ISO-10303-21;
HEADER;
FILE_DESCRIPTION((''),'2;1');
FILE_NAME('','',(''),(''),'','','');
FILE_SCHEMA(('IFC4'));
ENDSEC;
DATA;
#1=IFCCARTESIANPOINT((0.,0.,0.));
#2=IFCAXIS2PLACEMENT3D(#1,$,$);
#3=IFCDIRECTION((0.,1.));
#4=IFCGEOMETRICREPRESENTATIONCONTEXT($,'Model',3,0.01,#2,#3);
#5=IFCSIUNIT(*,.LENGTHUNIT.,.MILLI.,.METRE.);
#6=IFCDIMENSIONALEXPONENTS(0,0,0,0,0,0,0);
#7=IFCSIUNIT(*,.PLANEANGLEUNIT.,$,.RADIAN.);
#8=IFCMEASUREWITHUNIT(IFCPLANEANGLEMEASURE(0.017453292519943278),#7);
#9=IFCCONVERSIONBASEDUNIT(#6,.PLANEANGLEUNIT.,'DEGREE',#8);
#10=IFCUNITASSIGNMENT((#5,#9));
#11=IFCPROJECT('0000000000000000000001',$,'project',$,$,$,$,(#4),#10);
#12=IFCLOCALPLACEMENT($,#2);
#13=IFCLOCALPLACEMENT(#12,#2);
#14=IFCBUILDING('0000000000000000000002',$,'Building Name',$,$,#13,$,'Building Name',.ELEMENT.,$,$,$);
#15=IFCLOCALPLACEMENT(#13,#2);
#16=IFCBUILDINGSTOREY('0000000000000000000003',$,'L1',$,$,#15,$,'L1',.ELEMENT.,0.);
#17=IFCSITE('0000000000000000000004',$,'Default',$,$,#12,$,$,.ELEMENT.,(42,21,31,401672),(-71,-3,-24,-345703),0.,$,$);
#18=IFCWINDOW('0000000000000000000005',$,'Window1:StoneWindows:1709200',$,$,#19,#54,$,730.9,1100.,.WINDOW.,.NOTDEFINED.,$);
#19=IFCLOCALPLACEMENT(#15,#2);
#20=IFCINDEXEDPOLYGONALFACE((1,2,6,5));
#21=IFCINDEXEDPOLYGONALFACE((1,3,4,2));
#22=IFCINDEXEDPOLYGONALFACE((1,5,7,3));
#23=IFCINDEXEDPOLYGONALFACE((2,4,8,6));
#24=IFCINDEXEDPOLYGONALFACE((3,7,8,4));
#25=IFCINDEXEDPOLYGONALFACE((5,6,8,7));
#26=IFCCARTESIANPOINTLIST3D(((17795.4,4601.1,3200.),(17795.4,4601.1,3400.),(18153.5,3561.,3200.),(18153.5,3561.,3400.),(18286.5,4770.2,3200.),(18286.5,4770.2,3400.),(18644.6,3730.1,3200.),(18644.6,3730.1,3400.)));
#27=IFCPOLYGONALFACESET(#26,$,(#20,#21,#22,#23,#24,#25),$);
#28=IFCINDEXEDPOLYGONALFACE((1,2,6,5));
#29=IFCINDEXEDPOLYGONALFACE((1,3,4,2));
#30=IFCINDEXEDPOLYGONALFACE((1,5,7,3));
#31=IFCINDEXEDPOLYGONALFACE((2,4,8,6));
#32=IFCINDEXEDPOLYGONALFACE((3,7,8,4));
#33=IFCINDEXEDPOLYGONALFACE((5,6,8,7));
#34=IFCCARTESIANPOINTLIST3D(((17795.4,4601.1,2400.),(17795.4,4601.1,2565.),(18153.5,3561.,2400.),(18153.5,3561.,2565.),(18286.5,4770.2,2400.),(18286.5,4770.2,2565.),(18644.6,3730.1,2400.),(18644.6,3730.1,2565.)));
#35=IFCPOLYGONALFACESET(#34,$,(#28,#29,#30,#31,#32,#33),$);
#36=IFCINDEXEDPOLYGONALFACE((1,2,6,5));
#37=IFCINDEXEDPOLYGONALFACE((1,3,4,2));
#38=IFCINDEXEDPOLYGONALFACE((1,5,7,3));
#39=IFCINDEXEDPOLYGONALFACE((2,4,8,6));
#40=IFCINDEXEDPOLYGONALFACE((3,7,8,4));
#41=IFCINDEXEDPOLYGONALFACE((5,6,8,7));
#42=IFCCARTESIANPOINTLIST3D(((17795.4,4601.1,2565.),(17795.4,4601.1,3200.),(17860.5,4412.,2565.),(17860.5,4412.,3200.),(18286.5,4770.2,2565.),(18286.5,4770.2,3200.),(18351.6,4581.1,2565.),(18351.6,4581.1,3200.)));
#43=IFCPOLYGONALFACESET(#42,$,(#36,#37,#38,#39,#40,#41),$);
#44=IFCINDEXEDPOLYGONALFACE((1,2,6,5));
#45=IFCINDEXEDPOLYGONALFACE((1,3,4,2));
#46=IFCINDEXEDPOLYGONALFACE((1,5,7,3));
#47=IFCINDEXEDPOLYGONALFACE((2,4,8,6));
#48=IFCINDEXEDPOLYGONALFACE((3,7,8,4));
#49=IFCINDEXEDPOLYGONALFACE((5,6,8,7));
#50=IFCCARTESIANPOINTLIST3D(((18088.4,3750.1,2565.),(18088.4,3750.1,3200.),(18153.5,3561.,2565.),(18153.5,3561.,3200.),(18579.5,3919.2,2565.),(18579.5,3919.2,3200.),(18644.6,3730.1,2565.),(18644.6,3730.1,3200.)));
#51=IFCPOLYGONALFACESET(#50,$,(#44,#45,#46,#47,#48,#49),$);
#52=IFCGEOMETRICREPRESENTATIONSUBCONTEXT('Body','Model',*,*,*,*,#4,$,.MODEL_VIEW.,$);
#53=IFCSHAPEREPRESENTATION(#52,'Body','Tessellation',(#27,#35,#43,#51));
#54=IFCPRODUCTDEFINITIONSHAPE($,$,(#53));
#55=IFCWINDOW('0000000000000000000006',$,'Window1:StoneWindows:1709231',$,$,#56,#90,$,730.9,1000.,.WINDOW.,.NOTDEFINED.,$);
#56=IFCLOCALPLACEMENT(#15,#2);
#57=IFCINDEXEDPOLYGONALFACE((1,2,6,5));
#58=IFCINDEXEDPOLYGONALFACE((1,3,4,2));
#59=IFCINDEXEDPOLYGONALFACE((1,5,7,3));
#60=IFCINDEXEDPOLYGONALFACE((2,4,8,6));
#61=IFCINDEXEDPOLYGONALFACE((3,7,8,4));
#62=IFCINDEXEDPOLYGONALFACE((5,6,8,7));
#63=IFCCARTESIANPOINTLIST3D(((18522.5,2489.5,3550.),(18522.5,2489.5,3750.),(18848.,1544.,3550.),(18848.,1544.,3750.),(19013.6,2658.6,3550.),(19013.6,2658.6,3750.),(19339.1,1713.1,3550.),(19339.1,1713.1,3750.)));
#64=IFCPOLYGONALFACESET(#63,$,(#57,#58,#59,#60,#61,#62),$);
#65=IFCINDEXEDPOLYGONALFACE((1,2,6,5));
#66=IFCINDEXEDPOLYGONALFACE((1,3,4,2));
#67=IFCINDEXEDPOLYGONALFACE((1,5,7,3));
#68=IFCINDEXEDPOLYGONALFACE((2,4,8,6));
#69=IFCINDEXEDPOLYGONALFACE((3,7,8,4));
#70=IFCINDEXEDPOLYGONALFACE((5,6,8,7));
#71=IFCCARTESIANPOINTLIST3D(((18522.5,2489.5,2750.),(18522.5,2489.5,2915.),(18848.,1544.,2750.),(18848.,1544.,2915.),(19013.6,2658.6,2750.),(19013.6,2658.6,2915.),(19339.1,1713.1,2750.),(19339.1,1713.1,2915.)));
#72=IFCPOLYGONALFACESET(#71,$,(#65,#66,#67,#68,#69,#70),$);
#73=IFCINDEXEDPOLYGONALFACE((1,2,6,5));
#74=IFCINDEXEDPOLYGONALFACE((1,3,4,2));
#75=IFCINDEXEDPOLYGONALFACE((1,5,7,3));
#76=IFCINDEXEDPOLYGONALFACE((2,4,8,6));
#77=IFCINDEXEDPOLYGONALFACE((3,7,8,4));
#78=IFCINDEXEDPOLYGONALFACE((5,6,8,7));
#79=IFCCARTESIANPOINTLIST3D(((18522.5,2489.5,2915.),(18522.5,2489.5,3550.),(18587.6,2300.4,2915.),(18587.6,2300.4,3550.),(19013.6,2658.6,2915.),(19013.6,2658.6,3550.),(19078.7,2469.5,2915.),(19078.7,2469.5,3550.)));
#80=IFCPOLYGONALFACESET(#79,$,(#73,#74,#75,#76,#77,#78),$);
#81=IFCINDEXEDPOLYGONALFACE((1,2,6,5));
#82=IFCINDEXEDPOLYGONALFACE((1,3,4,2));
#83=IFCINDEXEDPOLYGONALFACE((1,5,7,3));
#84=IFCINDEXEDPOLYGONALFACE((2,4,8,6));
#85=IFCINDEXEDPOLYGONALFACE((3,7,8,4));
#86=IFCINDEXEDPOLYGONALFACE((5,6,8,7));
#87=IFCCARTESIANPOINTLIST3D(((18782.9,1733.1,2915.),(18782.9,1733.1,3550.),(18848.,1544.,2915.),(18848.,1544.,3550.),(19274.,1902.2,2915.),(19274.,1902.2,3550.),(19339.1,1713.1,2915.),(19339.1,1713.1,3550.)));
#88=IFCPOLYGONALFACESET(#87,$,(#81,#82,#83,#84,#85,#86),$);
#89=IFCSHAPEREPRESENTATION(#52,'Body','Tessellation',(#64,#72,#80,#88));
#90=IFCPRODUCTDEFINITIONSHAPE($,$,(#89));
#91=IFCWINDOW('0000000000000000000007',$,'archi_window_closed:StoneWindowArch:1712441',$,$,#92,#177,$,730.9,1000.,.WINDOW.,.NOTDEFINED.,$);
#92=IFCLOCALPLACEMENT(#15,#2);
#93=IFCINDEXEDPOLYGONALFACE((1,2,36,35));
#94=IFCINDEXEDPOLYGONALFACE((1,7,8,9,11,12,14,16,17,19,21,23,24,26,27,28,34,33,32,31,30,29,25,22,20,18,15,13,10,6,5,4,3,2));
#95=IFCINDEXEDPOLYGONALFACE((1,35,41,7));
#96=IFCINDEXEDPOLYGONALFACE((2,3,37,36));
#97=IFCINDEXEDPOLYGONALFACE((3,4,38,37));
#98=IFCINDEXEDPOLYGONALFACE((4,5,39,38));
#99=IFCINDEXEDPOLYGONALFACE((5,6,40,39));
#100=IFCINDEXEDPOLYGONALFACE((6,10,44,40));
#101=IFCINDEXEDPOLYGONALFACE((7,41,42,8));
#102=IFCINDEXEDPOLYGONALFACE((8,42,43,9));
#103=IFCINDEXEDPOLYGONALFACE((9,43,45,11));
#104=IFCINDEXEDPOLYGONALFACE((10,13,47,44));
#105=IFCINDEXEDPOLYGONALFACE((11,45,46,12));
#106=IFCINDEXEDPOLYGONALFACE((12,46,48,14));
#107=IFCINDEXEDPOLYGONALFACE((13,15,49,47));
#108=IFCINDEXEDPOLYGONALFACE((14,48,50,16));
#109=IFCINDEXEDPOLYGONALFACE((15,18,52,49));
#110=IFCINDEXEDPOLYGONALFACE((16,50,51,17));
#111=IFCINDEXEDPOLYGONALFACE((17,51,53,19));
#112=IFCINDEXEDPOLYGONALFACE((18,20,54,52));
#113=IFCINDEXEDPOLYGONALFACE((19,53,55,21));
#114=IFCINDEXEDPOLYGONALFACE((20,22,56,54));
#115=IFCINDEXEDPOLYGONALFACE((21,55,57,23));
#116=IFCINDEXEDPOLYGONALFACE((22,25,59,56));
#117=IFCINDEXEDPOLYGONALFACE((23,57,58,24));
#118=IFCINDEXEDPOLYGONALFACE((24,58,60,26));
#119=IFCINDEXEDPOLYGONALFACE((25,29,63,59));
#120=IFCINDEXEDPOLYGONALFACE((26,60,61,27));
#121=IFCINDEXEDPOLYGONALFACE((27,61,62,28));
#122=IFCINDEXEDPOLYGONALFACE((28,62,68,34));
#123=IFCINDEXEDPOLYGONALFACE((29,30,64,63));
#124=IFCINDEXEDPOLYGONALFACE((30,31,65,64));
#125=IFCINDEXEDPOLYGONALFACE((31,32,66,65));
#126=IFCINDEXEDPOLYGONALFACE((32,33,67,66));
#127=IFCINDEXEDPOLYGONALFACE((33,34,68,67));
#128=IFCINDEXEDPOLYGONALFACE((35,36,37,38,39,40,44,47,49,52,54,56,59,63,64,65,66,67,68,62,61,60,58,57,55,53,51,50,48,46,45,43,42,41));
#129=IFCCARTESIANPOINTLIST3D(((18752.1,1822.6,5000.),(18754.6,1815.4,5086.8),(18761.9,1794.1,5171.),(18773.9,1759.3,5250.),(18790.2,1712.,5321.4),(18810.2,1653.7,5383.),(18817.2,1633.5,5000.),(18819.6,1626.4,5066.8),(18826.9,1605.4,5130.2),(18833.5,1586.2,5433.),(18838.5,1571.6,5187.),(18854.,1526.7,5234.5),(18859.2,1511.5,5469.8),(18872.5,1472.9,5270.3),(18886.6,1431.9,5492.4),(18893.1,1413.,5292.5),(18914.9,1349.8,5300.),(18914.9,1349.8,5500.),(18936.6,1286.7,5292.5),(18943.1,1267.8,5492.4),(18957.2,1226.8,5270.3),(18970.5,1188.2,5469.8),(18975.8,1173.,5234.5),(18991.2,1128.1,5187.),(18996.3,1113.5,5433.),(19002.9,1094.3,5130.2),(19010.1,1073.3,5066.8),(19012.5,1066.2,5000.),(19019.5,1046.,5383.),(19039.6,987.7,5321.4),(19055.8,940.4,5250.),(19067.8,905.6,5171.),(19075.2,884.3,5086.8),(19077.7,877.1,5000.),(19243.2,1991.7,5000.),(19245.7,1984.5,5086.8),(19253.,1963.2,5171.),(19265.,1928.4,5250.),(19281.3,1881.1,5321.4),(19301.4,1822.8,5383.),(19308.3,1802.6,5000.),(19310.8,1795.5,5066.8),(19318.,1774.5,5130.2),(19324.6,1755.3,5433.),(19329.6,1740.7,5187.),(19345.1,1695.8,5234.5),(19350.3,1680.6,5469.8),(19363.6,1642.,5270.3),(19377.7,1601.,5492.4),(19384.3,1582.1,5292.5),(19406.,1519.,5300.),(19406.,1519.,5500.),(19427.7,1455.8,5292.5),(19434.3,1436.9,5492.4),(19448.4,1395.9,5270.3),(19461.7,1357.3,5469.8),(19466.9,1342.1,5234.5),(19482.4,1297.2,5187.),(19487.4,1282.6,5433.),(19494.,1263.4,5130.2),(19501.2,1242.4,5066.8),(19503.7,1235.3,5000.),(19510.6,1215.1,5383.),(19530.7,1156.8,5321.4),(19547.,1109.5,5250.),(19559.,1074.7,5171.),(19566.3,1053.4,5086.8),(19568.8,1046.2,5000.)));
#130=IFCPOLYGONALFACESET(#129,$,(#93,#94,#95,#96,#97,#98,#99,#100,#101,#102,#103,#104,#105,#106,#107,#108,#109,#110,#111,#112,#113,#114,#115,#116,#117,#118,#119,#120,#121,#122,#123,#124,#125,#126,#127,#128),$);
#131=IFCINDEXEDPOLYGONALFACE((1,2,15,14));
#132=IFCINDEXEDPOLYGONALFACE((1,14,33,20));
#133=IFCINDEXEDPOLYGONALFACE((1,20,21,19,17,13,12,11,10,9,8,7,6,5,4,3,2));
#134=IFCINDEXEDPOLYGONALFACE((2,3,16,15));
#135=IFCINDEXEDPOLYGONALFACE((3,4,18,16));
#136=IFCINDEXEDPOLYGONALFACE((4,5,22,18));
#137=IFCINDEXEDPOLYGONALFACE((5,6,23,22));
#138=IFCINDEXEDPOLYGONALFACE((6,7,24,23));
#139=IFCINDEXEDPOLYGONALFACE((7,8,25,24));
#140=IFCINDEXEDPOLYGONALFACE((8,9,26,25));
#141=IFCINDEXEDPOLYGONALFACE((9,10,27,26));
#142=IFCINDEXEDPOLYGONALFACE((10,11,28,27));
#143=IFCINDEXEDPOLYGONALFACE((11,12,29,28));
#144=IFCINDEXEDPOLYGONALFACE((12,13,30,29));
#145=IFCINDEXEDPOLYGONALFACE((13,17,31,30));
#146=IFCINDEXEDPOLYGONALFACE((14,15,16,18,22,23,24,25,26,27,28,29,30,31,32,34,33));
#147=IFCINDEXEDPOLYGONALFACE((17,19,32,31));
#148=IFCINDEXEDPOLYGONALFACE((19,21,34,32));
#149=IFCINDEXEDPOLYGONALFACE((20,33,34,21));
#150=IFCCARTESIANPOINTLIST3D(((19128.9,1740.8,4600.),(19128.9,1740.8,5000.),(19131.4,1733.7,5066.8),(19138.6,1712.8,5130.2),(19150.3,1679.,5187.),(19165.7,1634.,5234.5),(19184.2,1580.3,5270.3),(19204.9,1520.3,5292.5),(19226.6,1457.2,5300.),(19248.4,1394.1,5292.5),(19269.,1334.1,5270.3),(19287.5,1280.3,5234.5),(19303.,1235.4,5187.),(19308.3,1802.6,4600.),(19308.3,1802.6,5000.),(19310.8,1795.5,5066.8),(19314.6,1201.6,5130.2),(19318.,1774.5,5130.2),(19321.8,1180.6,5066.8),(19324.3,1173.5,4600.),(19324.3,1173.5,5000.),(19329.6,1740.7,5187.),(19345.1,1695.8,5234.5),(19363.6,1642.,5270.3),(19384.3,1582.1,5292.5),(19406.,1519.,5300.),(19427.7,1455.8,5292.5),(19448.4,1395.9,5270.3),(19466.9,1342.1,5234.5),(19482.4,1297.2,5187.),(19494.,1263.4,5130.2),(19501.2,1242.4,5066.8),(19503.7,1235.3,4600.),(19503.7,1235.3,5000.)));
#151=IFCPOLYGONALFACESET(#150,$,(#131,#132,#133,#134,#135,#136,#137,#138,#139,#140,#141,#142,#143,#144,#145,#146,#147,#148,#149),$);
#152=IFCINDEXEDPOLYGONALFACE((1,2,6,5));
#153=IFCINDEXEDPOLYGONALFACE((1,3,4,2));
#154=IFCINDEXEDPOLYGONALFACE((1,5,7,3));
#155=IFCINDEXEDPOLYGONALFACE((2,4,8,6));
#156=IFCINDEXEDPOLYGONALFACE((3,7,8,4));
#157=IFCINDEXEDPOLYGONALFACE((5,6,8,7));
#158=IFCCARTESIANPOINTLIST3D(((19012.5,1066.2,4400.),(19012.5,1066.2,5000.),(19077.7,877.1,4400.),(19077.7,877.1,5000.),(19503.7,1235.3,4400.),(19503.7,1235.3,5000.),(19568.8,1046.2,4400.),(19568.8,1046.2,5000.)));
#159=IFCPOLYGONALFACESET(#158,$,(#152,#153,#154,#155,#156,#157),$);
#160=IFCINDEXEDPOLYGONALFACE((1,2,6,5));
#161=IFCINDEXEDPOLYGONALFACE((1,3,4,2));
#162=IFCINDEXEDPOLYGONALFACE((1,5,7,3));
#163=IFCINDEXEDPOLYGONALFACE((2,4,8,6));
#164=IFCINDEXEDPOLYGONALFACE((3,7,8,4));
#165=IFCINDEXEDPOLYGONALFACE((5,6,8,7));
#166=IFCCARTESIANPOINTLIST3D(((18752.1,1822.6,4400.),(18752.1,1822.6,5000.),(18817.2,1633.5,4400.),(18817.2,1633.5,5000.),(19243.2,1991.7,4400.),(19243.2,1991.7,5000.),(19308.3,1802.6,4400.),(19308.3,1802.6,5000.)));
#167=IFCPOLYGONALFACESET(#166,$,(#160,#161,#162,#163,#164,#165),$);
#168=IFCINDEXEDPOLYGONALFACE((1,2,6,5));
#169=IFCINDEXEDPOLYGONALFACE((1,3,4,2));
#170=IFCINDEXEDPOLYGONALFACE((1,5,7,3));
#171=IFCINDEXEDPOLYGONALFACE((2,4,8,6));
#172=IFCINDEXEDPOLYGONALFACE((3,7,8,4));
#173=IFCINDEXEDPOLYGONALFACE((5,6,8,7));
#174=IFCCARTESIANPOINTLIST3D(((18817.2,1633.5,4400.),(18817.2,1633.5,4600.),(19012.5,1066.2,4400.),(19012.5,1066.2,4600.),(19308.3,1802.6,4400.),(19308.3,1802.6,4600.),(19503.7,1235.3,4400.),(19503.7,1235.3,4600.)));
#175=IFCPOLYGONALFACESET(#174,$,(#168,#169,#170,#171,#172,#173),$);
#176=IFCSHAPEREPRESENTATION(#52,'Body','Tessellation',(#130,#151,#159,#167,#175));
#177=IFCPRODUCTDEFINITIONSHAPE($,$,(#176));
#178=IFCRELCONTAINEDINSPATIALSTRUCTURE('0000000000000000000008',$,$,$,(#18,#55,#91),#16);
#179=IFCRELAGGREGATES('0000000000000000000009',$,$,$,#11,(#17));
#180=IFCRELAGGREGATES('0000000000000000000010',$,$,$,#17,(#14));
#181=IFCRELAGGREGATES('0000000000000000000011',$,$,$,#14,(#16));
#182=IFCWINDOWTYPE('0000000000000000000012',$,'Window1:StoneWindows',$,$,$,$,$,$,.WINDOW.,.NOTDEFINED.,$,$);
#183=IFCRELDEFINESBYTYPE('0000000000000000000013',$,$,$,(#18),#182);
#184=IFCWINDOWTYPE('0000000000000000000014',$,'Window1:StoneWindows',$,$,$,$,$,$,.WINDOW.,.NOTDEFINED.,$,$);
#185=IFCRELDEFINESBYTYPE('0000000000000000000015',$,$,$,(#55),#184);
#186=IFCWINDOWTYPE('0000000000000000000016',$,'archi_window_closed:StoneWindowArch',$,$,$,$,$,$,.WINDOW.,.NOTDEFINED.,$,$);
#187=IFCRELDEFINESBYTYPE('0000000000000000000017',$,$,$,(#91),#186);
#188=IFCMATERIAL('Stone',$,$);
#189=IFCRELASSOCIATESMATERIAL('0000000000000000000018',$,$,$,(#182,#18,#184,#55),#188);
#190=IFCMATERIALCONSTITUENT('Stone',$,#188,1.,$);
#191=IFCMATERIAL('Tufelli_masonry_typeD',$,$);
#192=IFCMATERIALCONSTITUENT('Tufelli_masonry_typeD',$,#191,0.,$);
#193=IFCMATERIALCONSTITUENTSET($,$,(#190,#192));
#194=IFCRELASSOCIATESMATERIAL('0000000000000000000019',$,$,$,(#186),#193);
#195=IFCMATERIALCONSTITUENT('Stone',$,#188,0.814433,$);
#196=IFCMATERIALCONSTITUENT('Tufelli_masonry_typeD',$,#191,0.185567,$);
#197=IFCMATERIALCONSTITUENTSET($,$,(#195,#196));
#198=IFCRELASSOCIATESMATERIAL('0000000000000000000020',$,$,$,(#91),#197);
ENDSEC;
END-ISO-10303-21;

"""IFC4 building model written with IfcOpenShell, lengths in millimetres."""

from ifc_helpers import new_model, entity, si_unit, converted_unit, direction, frame, origin, place, context, subcontext, project, spatial, line, arc, indexed_curve, outline, extrude, source, transform, mapped, material, constituent, constituent_set, type_object, type_shapes, element, save


model = new_model("IFC4")

# Units and contexts
model_context = context("Model", 3, precision=0.01, world=origin(), true_north=direction((0.0, 1.0)))
body_context = subcontext(model_context, "Body", "Model", "MODEL_VIEW")
ifc_project = project(units=[si_unit("LENGTHUNIT", "METRE", prefix="MILLI"), converted_unit("PLANEANGLEUNIT", "DEGREE", entity("IfcPlaneAngleMeasure", 0.017453292519943278), si_unit("PLANEANGLEUNIT", "RADIAN"), dimensions=[0, 0, 0, 0, 0, 0, 0])], contexts=[model_context])

# Site, building, storey
site_placement = place(None, origin())
site = spatial("IfcSite", under=ifc_project, at=site_placement, Name="Default", CompositionType="ELEMENT", RefLatitude=(42, 21, 31, 401672), RefLongitude=(-71, -3, -24, -345703), RefElevation=0.0)
building_placement = place(site_placement, origin())
building = spatial("IfcBuilding", under=site, at=building_placement, Name="Building Name", LongName="Building Name", CompositionType="ELEMENT")
storey_placement = place(building_placement, origin())
storey = spatial("IfcBuildingStorey", under=building, at=storey_placement, Name="L1", LongName="L1", CompositionType="ELEMENT", Elevation=0.0)

# Shared definitions
ifc_material_1 = material(Name="Stone")
ifc_material_2 = material(Name="Tufelli_masonry_typeD")

# Windows
window_type_1 = type_object("IfcWindowType", Name="Window1:StoneWindows", PartitioningType="NOTDEFINED", PredefinedType="WINDOW", material=ifc_material_1)
shared_shape_1 = source(origin(), body_context, "Body", "SweptSolid", [
    extrude(outline(indexed_curve([(-259.7, -550.0), (259.7, -550.0), (259.7, 550.0), (-259.7, 550.0), (-259.7, -550.0)], self_intersect=False)), frame((0.0, 0.0, 1600.0), z_axis=(0.0, 0.0, 1.0), x_axis=(0.0, 1.0, 0.0)), (0.0, 0.0, 1.0), 200.0),
    extrude(outline(indexed_curve([(-259.7, -550.0), (259.7, -550.0), (259.7, 550.0), (-259.7, 550.0), (-259.7, -550.0)], self_intersect=False)), frame((0.0, 0.0, 800.0), z_axis=(0.0, 0.0, 1.0), x_axis=(0.0, 1.0, 0.0)), (0.0, 0.0, 1.0), 165.0),
    extrude(outline(indexed_curve([(-259.7, -100.0), (259.7, -100.0), (259.7, 100.0), (-259.7, 100.0), (-259.7, -100.0)], self_intersect=False)), frame((-450.0, 0.0, 965.0), z_axis=(0.0, 0.0, 1.0), x_axis=(0.0, 1.0, 0.0)), (0.0, 0.0, 1.0), 635.0),
    extrude(outline(indexed_curve([(-259.7, -100.0), (259.7, -100.0), (259.7, 100.0), (-259.7, 100.0), (-259.7, -100.0)], self_intersect=False)), frame((450.0, 0.0, 965.0), z_axis=(0.0, 0.0, 1.0), x_axis=(0.0, 1.0, 0.0)), (0.0, 0.0, 1.0), 635.0),
])
type_shapes(window_type_1, [shared_shape_1])
window_1_placement = place(storey_placement, frame((18220.0, 4165.6, 1600.0), z_axis=(0.0, 0.0, 1.0), x_axis=(0.325568, -0.945519, 0.0)))
element("IfcWindow", 1, at=window_1_placement, inside=storey, type_object=window_type_1, material=ifc_material_1, Name="Window1:StoneWindows:1709200", OverallHeight=730.9, OverallWidth=1100.0, PartitioningType="NOTDEFINED", PredefinedType="WINDOW", context=body_context, shape_type="MappedRepresentation", body=[
    mapped(shared_shape_1, transform((0.0, 0.0, 0.0), scale=1.0)),
])
window_type_2 = type_object("IfcWindowType", Name="Window1:StoneWindows", PartitioningType="NOTDEFINED", PredefinedType="WINDOW", material=ifc_material_1)
shared_shape_2 = source(origin(), body_context, "Body", "SweptSolid", [
    extrude(outline(indexed_curve([(-259.7, -500.0), (259.7, -500.0), (259.7, 500.0), (-259.7, 500.0), (-259.7, -500.0)], self_intersect=False)), frame((0.0, 0.0, 1600.0), z_axis=(0.0, 0.0, 1.0), x_axis=(0.0, 1.0, 0.0)), (0.0, 0.0, 1.0), 200.0),
    extrude(outline(indexed_curve([(-259.7, -500.0), (259.7, -500.0), (259.7, 500.0), (-259.7, 500.0), (-259.7, -500.0)], self_intersect=False)), frame((0.0, 0.0, 800.0), z_axis=(0.0, 0.0, 1.0), x_axis=(0.0, 1.0, 0.0)), (0.0, 0.0, 1.0), 165.0),
    extrude(outline(indexed_curve([(-259.7, -100.0), (259.7, -100.0), (259.7, 100.0), (-259.7, 100.0), (-259.7, -100.0)], self_intersect=False)), frame((-400.0, 0.0, 965.0), z_axis=(0.0, 0.0, 1.0), x_axis=(0.0, 1.0, 0.0)), (0.0, 0.0, 1.0), 635.0),
    extrude(outline(indexed_curve([(-259.7, -100.0), (259.7, -100.0), (259.7, 100.0), (-259.7, 100.0), (-259.7, -100.0)], self_intersect=False)), frame((400.0, 0.0, 965.0), z_axis=(0.0, 0.0, 1.0), x_axis=(0.0, 1.0, 0.0)), (0.0, 0.0, 1.0), 635.0),
])
type_shapes(window_type_2, [shared_shape_2])
window_2_placement = place(storey_placement, frame((18930.8, 2101.3, 1950.0), z_axis=(0.0, 0.0, 1.0), x_axis=(0.325568, -0.945519, 0.0)))
element("IfcWindow", 2, at=window_2_placement, inside=storey, type_object=window_type_2, material=ifc_material_1, Name="Window1:StoneWindows:1709231", OverallHeight=730.9, OverallWidth=1000.0, PartitioningType="NOTDEFINED", PredefinedType="WINDOW", context=body_context, shape_type="MappedRepresentation", body=[
    mapped(shared_shape_2, transform((0.0, 0.0, 0.0), scale=1.0)),
])
ifc_constituent_1 = constituent(ifc_material_1, Name="Stone", fraction=0.814433)
ifc_constituent_2 = constituent(ifc_material_2, Name="Tufelli_masonry_typeD", fraction=0.185567)
ifc_constituent_set_1 = constituent_set(constituents=[ifc_constituent_1, ifc_constituent_2])
ifc_constituent_3 = constituent(ifc_material_1, Name="Stone", fraction=1.0)
ifc_constituent_4 = constituent(ifc_material_2, Name="Tufelli_masonry_typeD", fraction=0.0)
ifc_constituent_set_2 = constituent_set(constituents=[ifc_constituent_3, ifc_constituent_4])
window_type_3 = type_object("IfcWindowType", Name="archi_window_closed:StoneWindowArch", PartitioningType="NOTDEFINED", PredefinedType="WINDOW", material=ifc_constituent_set_2)
shared_shape_3 = source(origin(), body_context, "Body", "SweptSolid", [
    extrude(outline(indexed_curve([(300.0, 0.0), (500.0, 0.0), (0.0, 500.0), (-500.0, 0.0), (-300.0, 0.0), (0.0, 300.0)], segments=[line(1, 2), arc(2, 3, 4), line(4, 5), arc(5, 6, 1)], self_intersect=False)), frame((0.0, -259.7, 1400.0), z_axis=(0.0, -1.0, 0.0), x_axis=(1.0, 0.0, 0.0)), (0.0, 0.0, -1.0), 519.4),
    extrude(outline(indexed_curve([(-200.0, -300.0), (200.0, -300.0), (200.0, 300.0), (-200.0, 300.0), (-500.0, 0.0)], segments=[line(1, 2, 3, 4), arc(4, 5, 1)], self_intersect=False)), frame((0.0, 70.0, 1200.0), z_axis=(0.0, 1.0, 0.0), x_axis=(0.0, 0.0, -1.0)), (0.0, 0.0, 1.0), 189.7),
    extrude(outline(indexed_curve([(-259.7, -100.0), (259.7, -100.0), (259.7, 100.0), (-259.7, 100.0), (-259.7, -100.0)], self_intersect=False)), frame((400.0, 0.0, 800.0), z_axis=(0.0, 0.0, 1.0), x_axis=(0.0, 1.0, 0.0)), (0.0, 0.0, 1.0), 600.0),
    extrude(outline(indexed_curve([(-259.7, -100.0), (259.7, -100.0), (259.7, 100.0), (-259.7, 100.0), (-259.7, -100.0)], self_intersect=False)), frame((-400.0, 0.0, 800.0), z_axis=(0.0, 0.0, 1.0), x_axis=(0.0, 1.0, 0.0)), (0.0, 0.0, 1.0), 600.0),
    extrude(outline(indexed_curve([(-259.7, -300.0), (259.7, -300.0), (259.7, 300.0), (-259.7, 300.0), (-259.7, -300.0)], self_intersect=False)), frame((0.0, 0.0, 800.0), z_axis=(0.0, 0.0, 1.0), x_axis=(0.0, 1.0, 0.0)), (0.0, 0.0, 1.0), 200.0),
])
type_shapes(window_type_3, [shared_shape_3])
window_3_placement = place(storey_placement, frame((19160.4, 1434.4, 3600.0), z_axis=(0.0, 0.0, 1.0), x_axis=(0.325568, -0.945519, 0.0)))
element("IfcWindow", 3, at=window_3_placement, inside=storey, type_object=window_type_3, material=ifc_constituent_set_1, Name="archi_window_closed:StoneWindowArch:1712441", OverallHeight=730.9, OverallWidth=1000.0, PartitioningType="NOTDEFINED", PredefinedType="WINDOW", context=body_context, shape_type="MappedRepresentation", body=[
    mapped(shared_shape_3, transform((0.0, 0.0, 0.0), scale=1.0)),
])

save(model, "model.ifc")
